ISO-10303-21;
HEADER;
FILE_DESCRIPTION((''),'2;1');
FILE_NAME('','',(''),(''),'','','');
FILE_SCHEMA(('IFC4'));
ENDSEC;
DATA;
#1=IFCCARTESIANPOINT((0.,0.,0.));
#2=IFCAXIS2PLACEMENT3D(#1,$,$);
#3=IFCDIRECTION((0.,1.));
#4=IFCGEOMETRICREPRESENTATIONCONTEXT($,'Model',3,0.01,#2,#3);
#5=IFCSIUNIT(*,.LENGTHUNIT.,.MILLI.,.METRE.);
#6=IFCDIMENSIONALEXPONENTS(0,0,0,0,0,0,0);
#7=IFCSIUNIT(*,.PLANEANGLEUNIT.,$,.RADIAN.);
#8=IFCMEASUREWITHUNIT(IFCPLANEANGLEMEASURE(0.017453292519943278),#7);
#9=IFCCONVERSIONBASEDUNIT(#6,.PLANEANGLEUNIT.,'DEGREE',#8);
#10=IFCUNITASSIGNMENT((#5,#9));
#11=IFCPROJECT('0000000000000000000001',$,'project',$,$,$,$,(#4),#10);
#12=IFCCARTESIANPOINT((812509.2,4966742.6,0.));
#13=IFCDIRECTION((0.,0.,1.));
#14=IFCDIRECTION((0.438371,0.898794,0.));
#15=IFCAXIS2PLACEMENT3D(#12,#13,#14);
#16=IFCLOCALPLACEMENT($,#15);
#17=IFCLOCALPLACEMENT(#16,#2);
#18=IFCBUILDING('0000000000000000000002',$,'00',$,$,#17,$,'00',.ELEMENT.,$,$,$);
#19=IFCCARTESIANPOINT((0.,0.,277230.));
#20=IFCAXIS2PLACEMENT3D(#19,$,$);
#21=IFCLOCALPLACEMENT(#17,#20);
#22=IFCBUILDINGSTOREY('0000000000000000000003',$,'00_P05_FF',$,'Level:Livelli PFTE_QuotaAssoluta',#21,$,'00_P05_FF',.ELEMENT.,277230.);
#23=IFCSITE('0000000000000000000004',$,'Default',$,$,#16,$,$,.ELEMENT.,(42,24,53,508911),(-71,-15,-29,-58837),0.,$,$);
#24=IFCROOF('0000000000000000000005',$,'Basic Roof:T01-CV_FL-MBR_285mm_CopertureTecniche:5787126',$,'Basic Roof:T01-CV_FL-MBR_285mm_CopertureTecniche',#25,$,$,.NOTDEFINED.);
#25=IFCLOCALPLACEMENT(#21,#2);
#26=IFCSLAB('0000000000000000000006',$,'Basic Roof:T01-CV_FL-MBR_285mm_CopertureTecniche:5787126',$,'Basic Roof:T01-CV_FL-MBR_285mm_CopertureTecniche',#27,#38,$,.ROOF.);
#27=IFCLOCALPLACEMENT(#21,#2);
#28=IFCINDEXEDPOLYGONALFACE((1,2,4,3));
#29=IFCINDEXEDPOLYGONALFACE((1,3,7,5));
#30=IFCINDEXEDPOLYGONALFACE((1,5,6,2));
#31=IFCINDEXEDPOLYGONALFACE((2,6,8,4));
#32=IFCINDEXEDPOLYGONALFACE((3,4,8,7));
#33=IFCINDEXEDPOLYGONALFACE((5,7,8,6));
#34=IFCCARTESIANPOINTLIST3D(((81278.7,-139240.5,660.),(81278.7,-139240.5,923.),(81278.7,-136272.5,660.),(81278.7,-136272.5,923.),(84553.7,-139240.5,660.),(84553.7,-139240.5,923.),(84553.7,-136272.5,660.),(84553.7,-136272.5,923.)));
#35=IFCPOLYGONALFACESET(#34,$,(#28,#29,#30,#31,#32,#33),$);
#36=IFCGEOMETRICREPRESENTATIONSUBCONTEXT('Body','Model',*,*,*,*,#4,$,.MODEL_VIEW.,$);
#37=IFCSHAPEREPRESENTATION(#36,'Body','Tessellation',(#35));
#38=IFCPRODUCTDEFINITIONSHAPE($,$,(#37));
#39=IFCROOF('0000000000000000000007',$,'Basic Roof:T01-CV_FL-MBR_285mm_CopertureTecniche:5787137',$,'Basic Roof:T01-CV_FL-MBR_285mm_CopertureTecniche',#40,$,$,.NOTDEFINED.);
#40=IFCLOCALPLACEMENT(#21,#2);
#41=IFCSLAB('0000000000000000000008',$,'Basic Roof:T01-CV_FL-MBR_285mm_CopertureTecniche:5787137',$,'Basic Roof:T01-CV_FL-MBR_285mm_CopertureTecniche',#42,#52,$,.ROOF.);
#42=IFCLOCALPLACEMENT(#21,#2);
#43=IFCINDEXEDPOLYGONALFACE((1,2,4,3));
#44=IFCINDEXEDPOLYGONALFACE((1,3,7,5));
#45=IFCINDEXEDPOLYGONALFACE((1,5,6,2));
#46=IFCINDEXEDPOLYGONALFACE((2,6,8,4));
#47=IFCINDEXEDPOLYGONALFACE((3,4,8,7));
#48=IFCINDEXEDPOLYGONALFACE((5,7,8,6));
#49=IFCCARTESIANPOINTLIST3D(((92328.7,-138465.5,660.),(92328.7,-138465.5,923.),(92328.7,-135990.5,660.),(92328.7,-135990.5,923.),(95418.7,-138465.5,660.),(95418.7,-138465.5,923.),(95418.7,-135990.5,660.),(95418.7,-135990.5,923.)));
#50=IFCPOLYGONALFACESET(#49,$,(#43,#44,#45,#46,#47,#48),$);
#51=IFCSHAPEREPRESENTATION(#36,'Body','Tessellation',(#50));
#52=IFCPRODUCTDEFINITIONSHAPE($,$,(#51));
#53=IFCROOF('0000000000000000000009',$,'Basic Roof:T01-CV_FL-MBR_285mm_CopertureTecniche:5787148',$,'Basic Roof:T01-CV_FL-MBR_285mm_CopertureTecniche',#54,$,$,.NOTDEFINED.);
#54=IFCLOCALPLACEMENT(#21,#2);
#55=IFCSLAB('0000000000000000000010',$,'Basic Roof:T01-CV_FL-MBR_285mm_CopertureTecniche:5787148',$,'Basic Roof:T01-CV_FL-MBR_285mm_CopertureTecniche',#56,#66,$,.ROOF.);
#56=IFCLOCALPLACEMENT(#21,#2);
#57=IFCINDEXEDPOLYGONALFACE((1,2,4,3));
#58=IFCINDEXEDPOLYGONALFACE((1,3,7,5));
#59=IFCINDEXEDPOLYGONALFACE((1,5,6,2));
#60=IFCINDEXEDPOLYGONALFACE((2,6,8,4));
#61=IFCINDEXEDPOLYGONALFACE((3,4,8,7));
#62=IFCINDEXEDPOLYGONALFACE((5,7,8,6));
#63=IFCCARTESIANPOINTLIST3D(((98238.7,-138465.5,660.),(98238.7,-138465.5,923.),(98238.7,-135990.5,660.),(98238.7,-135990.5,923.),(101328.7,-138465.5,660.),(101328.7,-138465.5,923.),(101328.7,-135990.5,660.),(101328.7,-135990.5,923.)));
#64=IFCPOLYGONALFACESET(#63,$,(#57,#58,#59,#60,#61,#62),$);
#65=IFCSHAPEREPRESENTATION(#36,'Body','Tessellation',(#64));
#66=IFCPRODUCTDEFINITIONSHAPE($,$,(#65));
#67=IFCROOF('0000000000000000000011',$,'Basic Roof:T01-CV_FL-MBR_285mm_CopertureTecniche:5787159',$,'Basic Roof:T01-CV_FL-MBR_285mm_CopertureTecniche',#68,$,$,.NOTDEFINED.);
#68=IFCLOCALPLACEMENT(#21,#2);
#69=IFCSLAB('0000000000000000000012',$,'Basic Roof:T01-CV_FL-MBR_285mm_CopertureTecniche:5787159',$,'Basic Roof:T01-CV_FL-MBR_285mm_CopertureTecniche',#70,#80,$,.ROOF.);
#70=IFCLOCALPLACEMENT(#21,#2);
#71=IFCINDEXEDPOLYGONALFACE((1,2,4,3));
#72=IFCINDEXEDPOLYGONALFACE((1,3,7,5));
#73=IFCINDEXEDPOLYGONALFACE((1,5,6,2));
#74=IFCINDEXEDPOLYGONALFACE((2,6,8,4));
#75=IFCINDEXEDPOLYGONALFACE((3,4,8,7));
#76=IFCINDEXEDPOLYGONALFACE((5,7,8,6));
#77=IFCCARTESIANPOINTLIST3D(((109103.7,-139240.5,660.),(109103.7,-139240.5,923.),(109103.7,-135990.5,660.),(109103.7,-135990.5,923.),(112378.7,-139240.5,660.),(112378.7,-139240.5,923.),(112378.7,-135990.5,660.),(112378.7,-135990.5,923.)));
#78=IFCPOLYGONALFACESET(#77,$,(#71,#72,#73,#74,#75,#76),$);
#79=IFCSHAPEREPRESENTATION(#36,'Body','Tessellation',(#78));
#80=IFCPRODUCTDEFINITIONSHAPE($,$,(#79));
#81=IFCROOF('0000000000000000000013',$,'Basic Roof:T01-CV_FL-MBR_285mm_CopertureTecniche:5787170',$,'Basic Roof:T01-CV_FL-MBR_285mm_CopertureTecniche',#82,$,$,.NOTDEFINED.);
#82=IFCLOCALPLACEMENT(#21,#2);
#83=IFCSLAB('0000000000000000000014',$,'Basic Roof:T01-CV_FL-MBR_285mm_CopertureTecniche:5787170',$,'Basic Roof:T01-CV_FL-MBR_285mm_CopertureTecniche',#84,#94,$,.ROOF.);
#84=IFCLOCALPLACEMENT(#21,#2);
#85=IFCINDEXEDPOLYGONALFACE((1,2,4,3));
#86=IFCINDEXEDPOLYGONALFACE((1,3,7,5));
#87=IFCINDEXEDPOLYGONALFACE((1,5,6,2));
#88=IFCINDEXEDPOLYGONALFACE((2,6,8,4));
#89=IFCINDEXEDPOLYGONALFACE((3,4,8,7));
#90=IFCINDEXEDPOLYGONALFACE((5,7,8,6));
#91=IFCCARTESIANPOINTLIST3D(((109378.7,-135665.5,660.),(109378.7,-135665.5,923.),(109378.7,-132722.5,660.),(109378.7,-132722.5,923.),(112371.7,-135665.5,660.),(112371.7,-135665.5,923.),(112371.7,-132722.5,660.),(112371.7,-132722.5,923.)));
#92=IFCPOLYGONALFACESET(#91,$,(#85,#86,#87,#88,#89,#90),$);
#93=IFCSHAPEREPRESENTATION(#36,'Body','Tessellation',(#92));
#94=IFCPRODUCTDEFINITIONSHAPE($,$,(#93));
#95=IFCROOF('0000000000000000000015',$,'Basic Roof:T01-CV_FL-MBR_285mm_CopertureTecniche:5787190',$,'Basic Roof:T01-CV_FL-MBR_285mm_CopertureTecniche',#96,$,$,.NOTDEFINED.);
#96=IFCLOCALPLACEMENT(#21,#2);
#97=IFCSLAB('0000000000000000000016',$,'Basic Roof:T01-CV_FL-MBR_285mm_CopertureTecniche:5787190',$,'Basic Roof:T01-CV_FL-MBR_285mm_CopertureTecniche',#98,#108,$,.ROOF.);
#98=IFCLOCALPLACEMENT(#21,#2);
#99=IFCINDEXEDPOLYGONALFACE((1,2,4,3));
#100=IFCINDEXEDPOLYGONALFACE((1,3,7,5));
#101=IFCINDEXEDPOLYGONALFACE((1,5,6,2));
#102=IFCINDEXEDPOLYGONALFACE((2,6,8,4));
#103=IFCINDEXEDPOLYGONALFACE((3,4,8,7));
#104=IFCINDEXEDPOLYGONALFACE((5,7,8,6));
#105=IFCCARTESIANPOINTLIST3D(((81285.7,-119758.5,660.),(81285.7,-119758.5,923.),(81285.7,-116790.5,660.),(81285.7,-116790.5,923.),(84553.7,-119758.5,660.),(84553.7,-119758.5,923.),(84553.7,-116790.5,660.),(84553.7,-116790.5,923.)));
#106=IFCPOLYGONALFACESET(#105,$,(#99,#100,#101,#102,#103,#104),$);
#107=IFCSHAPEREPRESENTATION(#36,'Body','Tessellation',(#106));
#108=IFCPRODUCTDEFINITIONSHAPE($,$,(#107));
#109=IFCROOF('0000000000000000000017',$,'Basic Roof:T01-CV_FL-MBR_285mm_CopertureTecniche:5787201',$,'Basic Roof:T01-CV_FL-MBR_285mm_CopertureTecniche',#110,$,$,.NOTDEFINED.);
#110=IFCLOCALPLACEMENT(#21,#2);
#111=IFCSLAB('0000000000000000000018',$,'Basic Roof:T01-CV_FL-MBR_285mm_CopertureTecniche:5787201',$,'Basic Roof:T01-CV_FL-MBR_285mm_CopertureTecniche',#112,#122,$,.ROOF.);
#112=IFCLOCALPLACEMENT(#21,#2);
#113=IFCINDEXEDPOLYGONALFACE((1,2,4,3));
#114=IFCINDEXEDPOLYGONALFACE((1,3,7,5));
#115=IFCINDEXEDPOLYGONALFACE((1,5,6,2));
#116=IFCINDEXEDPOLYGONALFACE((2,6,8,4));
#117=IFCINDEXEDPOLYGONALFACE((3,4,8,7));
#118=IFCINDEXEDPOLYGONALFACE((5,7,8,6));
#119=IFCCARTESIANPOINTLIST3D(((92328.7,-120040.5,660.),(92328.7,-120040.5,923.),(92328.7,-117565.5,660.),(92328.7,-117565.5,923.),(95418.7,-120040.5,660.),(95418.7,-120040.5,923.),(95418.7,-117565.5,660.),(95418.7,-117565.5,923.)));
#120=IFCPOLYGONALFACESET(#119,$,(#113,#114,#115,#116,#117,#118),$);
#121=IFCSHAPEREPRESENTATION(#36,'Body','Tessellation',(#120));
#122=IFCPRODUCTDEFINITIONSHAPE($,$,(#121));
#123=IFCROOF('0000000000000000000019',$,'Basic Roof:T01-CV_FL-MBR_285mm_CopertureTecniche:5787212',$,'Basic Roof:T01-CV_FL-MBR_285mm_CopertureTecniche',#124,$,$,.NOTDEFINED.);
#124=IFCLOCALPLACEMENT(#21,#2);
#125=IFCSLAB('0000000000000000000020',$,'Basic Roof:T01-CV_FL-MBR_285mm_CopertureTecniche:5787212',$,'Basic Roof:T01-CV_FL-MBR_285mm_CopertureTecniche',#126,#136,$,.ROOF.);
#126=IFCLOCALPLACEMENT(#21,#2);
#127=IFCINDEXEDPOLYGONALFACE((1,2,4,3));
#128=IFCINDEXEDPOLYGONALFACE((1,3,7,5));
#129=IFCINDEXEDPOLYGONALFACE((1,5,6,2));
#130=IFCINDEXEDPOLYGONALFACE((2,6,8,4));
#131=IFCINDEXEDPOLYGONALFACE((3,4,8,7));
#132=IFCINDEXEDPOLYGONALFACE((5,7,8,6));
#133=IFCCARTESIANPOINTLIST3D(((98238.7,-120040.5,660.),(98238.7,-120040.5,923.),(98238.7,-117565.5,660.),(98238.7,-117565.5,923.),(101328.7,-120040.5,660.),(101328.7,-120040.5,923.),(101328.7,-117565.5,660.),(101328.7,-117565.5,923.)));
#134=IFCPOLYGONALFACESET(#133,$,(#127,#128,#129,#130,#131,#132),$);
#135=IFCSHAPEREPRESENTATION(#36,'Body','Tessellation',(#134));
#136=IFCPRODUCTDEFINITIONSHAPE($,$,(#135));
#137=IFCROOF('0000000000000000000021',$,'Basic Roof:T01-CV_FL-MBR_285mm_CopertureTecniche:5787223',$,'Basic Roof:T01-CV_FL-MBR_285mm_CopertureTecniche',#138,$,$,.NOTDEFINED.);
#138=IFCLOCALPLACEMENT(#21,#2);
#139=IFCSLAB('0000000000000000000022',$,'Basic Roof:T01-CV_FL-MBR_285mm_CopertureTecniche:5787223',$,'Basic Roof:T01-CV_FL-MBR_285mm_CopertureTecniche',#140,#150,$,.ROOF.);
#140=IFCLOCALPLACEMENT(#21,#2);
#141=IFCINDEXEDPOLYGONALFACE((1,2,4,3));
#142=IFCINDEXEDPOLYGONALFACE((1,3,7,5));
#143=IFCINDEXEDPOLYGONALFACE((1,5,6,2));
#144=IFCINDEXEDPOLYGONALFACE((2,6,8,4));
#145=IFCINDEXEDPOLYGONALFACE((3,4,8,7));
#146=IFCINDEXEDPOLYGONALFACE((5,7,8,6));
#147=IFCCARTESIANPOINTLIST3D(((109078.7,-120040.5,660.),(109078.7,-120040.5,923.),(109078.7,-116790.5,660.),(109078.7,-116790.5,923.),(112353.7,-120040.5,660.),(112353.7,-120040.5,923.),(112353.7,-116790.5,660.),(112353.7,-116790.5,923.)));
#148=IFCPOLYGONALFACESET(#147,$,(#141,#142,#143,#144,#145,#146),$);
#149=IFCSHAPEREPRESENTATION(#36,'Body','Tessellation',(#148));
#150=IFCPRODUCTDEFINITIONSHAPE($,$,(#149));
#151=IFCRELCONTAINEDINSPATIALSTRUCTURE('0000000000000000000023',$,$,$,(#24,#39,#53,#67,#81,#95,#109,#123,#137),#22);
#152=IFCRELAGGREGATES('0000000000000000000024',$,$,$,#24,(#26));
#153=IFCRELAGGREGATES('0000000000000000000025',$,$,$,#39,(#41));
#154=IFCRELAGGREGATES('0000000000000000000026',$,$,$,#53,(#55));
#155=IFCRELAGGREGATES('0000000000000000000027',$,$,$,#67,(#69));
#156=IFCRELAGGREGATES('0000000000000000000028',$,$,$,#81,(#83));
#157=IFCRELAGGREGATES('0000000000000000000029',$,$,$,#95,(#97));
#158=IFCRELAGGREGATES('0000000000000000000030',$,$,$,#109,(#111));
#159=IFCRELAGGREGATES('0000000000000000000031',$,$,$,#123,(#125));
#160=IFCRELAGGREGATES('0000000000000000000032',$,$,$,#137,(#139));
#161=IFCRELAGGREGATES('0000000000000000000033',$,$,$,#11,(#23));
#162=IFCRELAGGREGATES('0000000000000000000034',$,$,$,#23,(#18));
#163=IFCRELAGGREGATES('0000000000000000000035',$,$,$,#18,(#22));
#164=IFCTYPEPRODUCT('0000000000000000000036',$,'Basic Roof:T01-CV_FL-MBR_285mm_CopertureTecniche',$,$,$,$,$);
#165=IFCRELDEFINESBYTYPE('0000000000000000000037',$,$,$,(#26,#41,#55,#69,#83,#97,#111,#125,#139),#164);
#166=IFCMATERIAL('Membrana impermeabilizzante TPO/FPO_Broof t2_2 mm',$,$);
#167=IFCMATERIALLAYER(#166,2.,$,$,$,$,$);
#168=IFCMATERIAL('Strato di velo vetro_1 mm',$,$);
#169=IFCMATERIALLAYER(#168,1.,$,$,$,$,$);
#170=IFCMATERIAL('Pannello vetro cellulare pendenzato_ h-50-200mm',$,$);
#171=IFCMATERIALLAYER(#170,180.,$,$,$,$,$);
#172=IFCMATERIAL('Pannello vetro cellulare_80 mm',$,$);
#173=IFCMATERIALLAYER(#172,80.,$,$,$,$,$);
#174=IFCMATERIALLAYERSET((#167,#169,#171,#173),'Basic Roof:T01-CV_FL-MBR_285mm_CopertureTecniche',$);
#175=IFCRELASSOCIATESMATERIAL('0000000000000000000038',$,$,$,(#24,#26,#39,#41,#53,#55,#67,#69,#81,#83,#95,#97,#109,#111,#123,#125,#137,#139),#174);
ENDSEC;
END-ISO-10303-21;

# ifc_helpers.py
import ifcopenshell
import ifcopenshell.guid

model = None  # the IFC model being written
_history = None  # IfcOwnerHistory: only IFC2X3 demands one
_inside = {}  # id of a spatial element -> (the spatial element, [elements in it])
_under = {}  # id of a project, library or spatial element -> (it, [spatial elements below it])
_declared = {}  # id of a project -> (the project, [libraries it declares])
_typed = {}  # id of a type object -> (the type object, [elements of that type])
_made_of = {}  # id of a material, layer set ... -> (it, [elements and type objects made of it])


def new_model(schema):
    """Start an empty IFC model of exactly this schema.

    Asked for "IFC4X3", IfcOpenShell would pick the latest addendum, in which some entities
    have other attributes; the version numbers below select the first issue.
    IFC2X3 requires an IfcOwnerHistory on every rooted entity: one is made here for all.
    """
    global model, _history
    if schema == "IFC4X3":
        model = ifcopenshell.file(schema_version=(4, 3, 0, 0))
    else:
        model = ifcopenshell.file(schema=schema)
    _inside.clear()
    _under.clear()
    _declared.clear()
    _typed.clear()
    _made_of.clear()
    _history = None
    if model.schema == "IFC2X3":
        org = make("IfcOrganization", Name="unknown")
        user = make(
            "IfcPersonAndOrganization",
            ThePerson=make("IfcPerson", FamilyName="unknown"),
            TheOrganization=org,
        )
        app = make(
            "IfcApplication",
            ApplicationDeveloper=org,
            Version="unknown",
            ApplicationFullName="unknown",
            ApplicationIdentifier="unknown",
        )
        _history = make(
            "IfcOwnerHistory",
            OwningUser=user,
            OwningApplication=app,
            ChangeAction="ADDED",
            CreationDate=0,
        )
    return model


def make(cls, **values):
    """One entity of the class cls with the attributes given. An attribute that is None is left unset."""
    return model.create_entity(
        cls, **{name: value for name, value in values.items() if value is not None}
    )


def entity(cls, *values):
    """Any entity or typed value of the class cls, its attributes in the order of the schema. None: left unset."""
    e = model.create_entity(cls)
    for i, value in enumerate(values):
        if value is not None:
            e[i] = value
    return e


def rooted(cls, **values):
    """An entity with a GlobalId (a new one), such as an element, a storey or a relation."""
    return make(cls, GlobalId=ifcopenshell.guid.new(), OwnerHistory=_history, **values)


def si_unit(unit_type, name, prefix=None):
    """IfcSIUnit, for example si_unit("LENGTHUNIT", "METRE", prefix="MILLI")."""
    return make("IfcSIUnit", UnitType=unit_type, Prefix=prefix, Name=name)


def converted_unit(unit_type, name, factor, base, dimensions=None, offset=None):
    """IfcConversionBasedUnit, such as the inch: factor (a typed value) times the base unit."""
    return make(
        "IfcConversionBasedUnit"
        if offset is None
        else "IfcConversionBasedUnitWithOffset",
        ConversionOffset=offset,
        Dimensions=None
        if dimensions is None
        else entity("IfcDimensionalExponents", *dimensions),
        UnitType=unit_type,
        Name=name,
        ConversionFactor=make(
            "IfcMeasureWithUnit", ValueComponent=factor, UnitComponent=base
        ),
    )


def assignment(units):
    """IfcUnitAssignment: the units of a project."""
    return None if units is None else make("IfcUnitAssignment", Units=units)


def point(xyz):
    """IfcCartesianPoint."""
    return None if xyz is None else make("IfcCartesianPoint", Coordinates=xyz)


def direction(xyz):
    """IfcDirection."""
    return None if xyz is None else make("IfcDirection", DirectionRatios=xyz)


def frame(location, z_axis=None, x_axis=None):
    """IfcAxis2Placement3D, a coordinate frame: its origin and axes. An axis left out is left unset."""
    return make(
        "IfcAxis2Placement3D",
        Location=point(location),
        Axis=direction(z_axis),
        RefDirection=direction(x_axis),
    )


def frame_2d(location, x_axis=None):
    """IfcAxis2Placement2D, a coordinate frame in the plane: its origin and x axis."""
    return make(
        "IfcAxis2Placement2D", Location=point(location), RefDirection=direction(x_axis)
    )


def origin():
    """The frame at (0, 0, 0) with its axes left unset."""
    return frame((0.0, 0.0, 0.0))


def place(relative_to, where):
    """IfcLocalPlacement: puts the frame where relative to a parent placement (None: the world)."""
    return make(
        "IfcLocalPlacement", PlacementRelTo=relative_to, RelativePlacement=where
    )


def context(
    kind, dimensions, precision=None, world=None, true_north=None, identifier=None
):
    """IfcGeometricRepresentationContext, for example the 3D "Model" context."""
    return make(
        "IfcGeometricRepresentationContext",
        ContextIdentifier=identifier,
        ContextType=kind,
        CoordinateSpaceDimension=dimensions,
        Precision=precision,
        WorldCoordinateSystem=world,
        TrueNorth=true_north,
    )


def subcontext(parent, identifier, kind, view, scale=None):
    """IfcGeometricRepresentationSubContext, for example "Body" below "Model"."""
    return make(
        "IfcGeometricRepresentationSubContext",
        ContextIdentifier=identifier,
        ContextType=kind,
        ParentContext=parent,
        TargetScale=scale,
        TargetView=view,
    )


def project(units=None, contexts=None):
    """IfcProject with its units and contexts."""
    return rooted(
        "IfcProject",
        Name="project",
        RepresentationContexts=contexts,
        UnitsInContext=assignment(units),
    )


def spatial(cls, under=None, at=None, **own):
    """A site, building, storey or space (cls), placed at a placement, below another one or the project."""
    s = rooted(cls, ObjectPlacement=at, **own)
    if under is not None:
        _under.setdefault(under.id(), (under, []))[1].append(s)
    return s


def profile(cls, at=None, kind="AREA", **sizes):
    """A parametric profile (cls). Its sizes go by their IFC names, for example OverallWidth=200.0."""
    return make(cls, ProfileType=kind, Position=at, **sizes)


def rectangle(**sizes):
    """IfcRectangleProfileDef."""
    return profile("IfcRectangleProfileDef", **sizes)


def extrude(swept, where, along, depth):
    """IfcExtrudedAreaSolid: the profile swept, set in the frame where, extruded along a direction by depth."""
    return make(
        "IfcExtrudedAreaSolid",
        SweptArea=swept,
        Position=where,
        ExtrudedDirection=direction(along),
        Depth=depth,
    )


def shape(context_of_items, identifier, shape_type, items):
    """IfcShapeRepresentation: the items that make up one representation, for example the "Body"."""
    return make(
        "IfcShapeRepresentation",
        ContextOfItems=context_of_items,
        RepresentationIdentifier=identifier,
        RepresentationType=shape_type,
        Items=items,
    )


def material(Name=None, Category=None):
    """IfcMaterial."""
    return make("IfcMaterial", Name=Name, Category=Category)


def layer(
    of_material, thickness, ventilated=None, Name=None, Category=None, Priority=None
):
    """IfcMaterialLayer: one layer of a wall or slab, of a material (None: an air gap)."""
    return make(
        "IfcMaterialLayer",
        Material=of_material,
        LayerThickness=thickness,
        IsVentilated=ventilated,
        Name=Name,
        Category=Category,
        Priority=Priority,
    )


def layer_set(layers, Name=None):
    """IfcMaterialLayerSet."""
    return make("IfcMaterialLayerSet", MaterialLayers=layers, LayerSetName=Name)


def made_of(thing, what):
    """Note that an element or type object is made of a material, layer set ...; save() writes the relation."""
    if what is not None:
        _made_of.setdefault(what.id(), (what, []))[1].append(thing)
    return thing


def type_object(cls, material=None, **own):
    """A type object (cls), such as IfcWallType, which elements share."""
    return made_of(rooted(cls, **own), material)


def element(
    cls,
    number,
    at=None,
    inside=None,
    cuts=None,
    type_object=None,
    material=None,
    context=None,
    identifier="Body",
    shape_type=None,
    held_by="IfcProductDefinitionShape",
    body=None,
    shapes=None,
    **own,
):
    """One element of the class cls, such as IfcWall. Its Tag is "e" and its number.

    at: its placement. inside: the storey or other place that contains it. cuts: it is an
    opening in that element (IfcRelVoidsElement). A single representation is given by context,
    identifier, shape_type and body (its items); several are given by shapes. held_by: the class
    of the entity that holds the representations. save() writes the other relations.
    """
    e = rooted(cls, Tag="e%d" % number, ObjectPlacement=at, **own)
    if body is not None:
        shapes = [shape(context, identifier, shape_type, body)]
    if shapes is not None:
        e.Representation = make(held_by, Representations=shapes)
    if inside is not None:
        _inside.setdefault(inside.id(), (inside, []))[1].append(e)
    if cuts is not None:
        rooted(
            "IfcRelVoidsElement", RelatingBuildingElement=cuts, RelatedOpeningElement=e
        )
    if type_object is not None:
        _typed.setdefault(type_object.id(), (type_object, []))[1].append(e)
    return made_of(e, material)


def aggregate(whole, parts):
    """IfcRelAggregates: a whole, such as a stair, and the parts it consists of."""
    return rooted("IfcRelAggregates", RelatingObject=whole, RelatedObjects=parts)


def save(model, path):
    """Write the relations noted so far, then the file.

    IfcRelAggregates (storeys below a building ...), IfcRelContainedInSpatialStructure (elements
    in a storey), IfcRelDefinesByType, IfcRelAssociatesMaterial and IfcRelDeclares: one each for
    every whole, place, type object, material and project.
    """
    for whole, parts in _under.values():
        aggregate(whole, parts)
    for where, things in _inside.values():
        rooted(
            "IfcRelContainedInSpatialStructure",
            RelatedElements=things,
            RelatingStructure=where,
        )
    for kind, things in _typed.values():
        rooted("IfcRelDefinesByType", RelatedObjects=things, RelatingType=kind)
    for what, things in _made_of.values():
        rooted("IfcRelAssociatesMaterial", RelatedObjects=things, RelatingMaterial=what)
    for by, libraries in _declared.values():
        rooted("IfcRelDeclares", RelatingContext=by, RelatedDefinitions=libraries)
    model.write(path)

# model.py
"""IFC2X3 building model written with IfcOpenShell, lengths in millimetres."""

from ifc_helpers import new_model, entity, si_unit, converted_unit, direction, frame, frame_2d, origin, place, context, subcontext, project, spatial, rectangle, extrude, material, layer, layer_set, type_object, element, aggregate, save


model = new_model("IFC2X3")

# Units and contexts
model_context = context("Model", 3, precision=0.01, world=origin(), true_north=direction((0.0, 1.0)))
body_context = subcontext(model_context, "Body", "Model", "MODEL_VIEW")
ifc_project = project(units=[si_unit("LENGTHUNIT", "METRE", prefix="MILLI"), converted_unit("PLANEANGLEUNIT", "DEGREE", entity("IfcPlaneAngleMeasure", 0.017453292519943278), si_unit("PLANEANGLEUNIT", "RADIAN"), dimensions=[0, 0, 0, 0, 0, 0, 0])], contexts=[model_context])

# Site, building, storey
site_placement = place(None, frame((812509.2, 4966742.6, 0.0), z_axis=(0.0, 0.0, 1.0), x_axis=(0.438371, 0.898794, 0.0)))
site = spatial("IfcSite", under=ifc_project, at=site_placement, Name="Default", CompositionType="ELEMENT", RefLatitude=(42, 24, 53, 508911), RefLongitude=(-71, -15, -29, -58837), RefElevation=0.0)
building_placement = place(site_placement, origin())
building = spatial("IfcBuilding", under=site, at=building_placement, Name="00", LongName="00", CompositionType="ELEMENT")
storey_placement = place(building_placement, frame((0.0, 0.0, 277230.0)))
storey = spatial("IfcBuildingStorey", under=building, at=storey_placement, Name="00_P05_FF", ObjectType="Level:Livelli PFTE_QuotaAssoluta", LongName="00_P05_FF", CompositionType="ELEMENT", Elevation=277230.0)

# Roofs, slabs
ifc_material_1 = material(Name="Membrana impermeabilizzante TPO/FPO_Broof t2_2 mm")
ifc_layer_1 = layer(ifc_material_1, 2.0)
ifc_material_2 = material(Name="Strato di velo vetro_1 mm")
ifc_layer_2 = layer(ifc_material_2, 1.0)
ifc_material_3 = material(Name="Pannello vetro cellulare pendenzato_ h-50-200mm")
ifc_layer_3 = layer(ifc_material_3, 180.0)
ifc_material_4 = material(Name="Pannello vetro cellulare_80 mm")
ifc_layer_4 = layer(ifc_material_4, 80.0)
ifc_layer_set = layer_set([ifc_layer_1, ifc_layer_2, ifc_layer_3, ifc_layer_4], Name="Basic Roof:T01-CV_FL-MBR_285mm_CopertureTecniche")
roof_1_placement = place(storey_placement, frame((81278.7, -139240.5, 660.0)))
roof_1 = element("IfcRoof", 1, at=roof_1_placement, inside=storey, material=ifc_layer_set, Name="Basic Roof:T01-CV_FL-MBR_285mm_CopertureTecniche:5787126", ObjectType="Basic Roof:T01-CV_FL-MBR_285mm_CopertureTecniche", ShapeType="NOTDEFINED")
type_product = type_object("IfcTypeProduct", Name="Basic Roof:T01-CV_FL-MBR_285mm_CopertureTecniche")
slab_1_placement = place(roof_1_placement, origin())
slab_1 = element("IfcSlab", 2, at=slab_1_placement, type_object=type_product, material=ifc_layer_set, Name="Basic Roof:T01-CV_FL-MBR_285mm_CopertureTecniche:5787126", ObjectType="Basic Roof:T01-CV_FL-MBR_285mm_CopertureTecniche", PredefinedType="ROOF", context=body_context, shape_type="SweptSolid", body=[
    extrude(rectangle(XDim=3275.0, YDim=2968.0, at=frame_2d((0.0, 0.0), x_axis=(-1.0, 0.0))), frame((1637.5, 1484.0, 0.0)), (0.0, 0.0, 1.0), 263.0),
])
aggregate(roof_1, [slab_1])
roof_2_placement = place(storey_placement, frame((92328.7, -138465.5, 660.0)))
roof_2 = element("IfcRoof", 3, at=roof_2_placement, inside=storey, material=ifc_layer_set, Name="Basic Roof:T01-CV_FL-MBR_285mm_CopertureTecniche:5787137", ObjectType="Basic Roof:T01-CV_FL-MBR_285mm_CopertureTecniche", ShapeType="NOTDEFINED")
slab_2_placement = place(roof_2_placement, origin())
slab_2 = element("IfcSlab", 4, at=slab_2_placement, type_object=type_product, material=ifc_layer_set, Name="Basic Roof:T01-CV_FL-MBR_285mm_CopertureTecniche:5787137", ObjectType="Basic Roof:T01-CV_FL-MBR_285mm_CopertureTecniche", PredefinedType="ROOF", context=body_context, shape_type="SweptSolid", body=[
    extrude(rectangle(XDim=3090.0, YDim=2475.0, at=frame_2d((0.0, 0.0), x_axis=(1.0, 0.0))), frame((1545.0, 1237.5, 0.0)), (0.0, 0.0, 1.0), 263.0),
])
aggregate(roof_2, [slab_2])
roof_3_placement = place(storey_placement, frame((98238.7, -138465.5, 660.0)))
roof_3 = element("IfcRoof", 5, at=roof_3_placement, inside=storey, material=ifc_layer_set, Name="Basic Roof:T01-CV_FL-MBR_285mm_CopertureTecniche:5787148", ObjectType="Basic Roof:T01-CV_FL-MBR_285mm_CopertureTecniche", ShapeType="NOTDEFINED")
slab_3_placement = place(roof_3_placement, origin())
slab_3 = element("IfcSlab", 6, at=slab_3_placement, type_object=type_product, material=ifc_layer_set, Name="Basic Roof:T01-CV_FL-MBR_285mm_CopertureTecniche:5787148", ObjectType="Basic Roof:T01-CV_FL-MBR_285mm_CopertureTecniche", PredefinedType="ROOF", context=body_context, shape_type="SweptSolid", body=[
    extrude(rectangle(XDim=3090.0, YDim=2475.0, at=frame_2d((0.0, 0.0), x_axis=(1.0, 0.0))), frame((1545.0, 1237.5, 0.0)), (0.0, 0.0, 1.0), 263.0),
])
aggregate(roof_3, [slab_3])
roof_4_placement = place(storey_placement, frame((109103.7, -139240.5, 660.0)))
roof_4 = element("IfcRoof", 7, at=roof_4_placement, inside=storey, material=ifc_layer_set, Name="Basic Roof:T01-CV_FL-MBR_285mm_CopertureTecniche:5787159", ObjectType="Basic Roof:T01-CV_FL-MBR_285mm_CopertureTecniche", ShapeType="NOTDEFINED")
slab_4_placement = place(roof_4_placement, origin())
slab_4 = element("IfcSlab", 8, at=slab_4_placement, type_object=type_product, material=ifc_layer_set, Name="Basic Roof:T01-CV_FL-MBR_285mm_CopertureTecniche:5787159", ObjectType="Basic Roof:T01-CV_FL-MBR_285mm_CopertureTecniche", PredefinedType="ROOF", context=body_context, shape_type="SweptSolid", body=[
    extrude(rectangle(XDim=3250.0, YDim=3275.0, at=frame_2d((0.0, 0.0), x_axis=(0.0, 1.0))), frame((1637.5, 1625.0, 0.0)), (0.0, 0.0, 1.0), 263.0),
])
aggregate(roof_4, [slab_4])
roof_5_placement = place(storey_placement, frame((109378.7, -135665.5, 660.0)))
roof_5 = element("IfcRoof", 9, at=roof_5_placement, inside=storey, material=ifc_layer_set, Name="Basic Roof:T01-CV_FL-MBR_285mm_CopertureTecniche:5787170", ObjectType="Basic Roof:T01-CV_FL-MBR_285mm_CopertureTecniche", ShapeType="NOTDEFINED")
slab_5_placement = place(roof_5_placement, origin())
slab_5 = element("IfcSlab", 10, at=slab_5_placement, type_object=type_product, material=ifc_layer_set, Name="Basic Roof:T01-CV_FL-MBR_285mm_CopertureTecniche:5787170", ObjectType="Basic Roof:T01-CV_FL-MBR_285mm_CopertureTecniche", PredefinedType="ROOF", context=body_context, shape_type="SweptSolid", body=[
    extrude(rectangle(XDim=2943.0, YDim=2993.0, at=frame_2d((0.0, 0.0), x_axis=(0.0, 1.0))), frame((1496.5, 1471.5, 0.0)), (0.0, 0.0, 1.0), 263.0),
])
aggregate(roof_5, [slab_5])
roof_6_placement = place(storey_placement, frame((81285.7, -119758.5, 660.0)))
roof_6 = element("IfcRoof", 11, at=roof_6_placement, inside=storey, material=ifc_layer_set, Name="Basic Roof:T01-CV_FL-MBR_285mm_CopertureTecniche:5787190", ObjectType="Basic Roof:T01-CV_FL-MBR_285mm_CopertureTecniche", ShapeType="NOTDEFINED")
slab_6_placement = place(roof_6_placement, origin())
slab_6 = element("IfcSlab", 12, at=slab_6_placement, type_object=type_product, material=ifc_layer_set, Name="Basic Roof:T01-CV_FL-MBR_285mm_CopertureTecniche:5787190", ObjectType="Basic Roof:T01-CV_FL-MBR_285mm_CopertureTecniche", PredefinedType="ROOF", context=body_context, shape_type="SweptSolid", body=[
    extrude(rectangle(XDim=2968.0, YDim=3268.0, at=frame_2d((0.0, 0.0), x_axis=(0.0, -1.0))), frame((1634.0, 1484.0, 0.0)), (0.0, 0.0, 1.0), 263.0),
])
aggregate(roof_6, [slab_6])
roof_7_placement = place(storey_placement, frame((92328.7, -120040.5, 660.0)))
roof_7 = element("IfcRoof", 13, at=roof_7_placement, inside=storey, material=ifc_layer_set, Name="Basic Roof:T01-CV_FL-MBR_285mm_CopertureTecniche:5787201", ObjectType="Basic Roof:T01-CV_FL-MBR_285mm_CopertureTecniche", ShapeType="NOTDEFINED")
slab_7_placement = place(roof_7_placement, origin())
slab_7 = element("IfcSlab", 14, at=slab_7_placement, type_object=type_product, material=ifc_layer_set, Name="Basic Roof:T01-CV_FL-MBR_285mm_CopertureTecniche:5787201", ObjectType="Basic Roof:T01-CV_FL-MBR_285mm_CopertureTecniche", PredefinedType="ROOF", context=body_context, shape_type="SweptSolid", body=[
    extrude(rectangle(XDim=3090.0, YDim=2475.0, at=frame_2d((0.0, 0.0), x_axis=(-1.0, 0.0))), frame((1545.0, 1237.5, 0.0)), (0.0, 0.0, 1.0), 263.0),
])
aggregate(roof_7, [slab_7])
roof_8_placement = place(storey_placement, frame((98238.7, -120040.5, 660.0)))
roof_8 = element("IfcRoof", 15, at=roof_8_placement, inside=storey, material=ifc_layer_set, Name="Basic Roof:T01-CV_FL-MBR_285mm_CopertureTecniche:5787212", ObjectType="Basic Roof:T01-CV_FL-MBR_285mm_CopertureTecniche", ShapeType="NOTDEFINED")
slab_8_placement = place(roof_8_placement, origin())
slab_8 = element("IfcSlab", 16, at=slab_8_placement, type_object=type_product, material=ifc_layer_set, Name="Basic Roof:T01-CV_FL-MBR_285mm_CopertureTecniche:5787212", ObjectType="Basic Roof:T01-CV_FL-MBR_285mm_CopertureTecniche", PredefinedType="ROOF", context=body_context, shape_type="SweptSolid", body=[
    extrude(rectangle(XDim=2475.0, YDim=3090.0, at=frame_2d((0.0, 0.0), x_axis=(0.0, 1.0))), frame((1545.0, 1237.5, 0.0)), (0.0, 0.0, 1.0), 263.0),
])
aggregate(roof_8, [slab_8])
roof_9_placement = place(storey_placement, frame((109078.7, -120040.5, 660.0)))
roof_9 = element("IfcRoof", 17, at=roof_9_placement, inside=storey, material=ifc_layer_set, Name="Basic Roof:T01-CV_FL-MBR_285mm_CopertureTecniche:5787223", ObjectType="Basic Roof:T01-CV_FL-MBR_285mm_CopertureTecniche", ShapeType="NOTDEFINED")
slab_9_placement = place(roof_9_placement, origin())
slab_9 = element("IfcSlab", 18, at=slab_9_placement, type_object=type_product, material=ifc_layer_set, Name="Basic Roof:T01-CV_FL-MBR_285mm_CopertureTecniche:5787223", ObjectType="Basic Roof:T01-CV_FL-MBR_285mm_CopertureTecniche", PredefinedType="ROOF", context=body_context, shape_type="SweptSolid", body=[
    extrude(rectangle(XDim=3250.0, YDim=3275.0, at=frame_2d((0.0, 0.0), x_axis=(0.0, 1.0))), frame((1637.5, 1625.0, 0.0)), (0.0, 0.0, 1.0), 263.0),
])
aggregate(roof_9, [slab_9])

save(model, "model.ifc")
